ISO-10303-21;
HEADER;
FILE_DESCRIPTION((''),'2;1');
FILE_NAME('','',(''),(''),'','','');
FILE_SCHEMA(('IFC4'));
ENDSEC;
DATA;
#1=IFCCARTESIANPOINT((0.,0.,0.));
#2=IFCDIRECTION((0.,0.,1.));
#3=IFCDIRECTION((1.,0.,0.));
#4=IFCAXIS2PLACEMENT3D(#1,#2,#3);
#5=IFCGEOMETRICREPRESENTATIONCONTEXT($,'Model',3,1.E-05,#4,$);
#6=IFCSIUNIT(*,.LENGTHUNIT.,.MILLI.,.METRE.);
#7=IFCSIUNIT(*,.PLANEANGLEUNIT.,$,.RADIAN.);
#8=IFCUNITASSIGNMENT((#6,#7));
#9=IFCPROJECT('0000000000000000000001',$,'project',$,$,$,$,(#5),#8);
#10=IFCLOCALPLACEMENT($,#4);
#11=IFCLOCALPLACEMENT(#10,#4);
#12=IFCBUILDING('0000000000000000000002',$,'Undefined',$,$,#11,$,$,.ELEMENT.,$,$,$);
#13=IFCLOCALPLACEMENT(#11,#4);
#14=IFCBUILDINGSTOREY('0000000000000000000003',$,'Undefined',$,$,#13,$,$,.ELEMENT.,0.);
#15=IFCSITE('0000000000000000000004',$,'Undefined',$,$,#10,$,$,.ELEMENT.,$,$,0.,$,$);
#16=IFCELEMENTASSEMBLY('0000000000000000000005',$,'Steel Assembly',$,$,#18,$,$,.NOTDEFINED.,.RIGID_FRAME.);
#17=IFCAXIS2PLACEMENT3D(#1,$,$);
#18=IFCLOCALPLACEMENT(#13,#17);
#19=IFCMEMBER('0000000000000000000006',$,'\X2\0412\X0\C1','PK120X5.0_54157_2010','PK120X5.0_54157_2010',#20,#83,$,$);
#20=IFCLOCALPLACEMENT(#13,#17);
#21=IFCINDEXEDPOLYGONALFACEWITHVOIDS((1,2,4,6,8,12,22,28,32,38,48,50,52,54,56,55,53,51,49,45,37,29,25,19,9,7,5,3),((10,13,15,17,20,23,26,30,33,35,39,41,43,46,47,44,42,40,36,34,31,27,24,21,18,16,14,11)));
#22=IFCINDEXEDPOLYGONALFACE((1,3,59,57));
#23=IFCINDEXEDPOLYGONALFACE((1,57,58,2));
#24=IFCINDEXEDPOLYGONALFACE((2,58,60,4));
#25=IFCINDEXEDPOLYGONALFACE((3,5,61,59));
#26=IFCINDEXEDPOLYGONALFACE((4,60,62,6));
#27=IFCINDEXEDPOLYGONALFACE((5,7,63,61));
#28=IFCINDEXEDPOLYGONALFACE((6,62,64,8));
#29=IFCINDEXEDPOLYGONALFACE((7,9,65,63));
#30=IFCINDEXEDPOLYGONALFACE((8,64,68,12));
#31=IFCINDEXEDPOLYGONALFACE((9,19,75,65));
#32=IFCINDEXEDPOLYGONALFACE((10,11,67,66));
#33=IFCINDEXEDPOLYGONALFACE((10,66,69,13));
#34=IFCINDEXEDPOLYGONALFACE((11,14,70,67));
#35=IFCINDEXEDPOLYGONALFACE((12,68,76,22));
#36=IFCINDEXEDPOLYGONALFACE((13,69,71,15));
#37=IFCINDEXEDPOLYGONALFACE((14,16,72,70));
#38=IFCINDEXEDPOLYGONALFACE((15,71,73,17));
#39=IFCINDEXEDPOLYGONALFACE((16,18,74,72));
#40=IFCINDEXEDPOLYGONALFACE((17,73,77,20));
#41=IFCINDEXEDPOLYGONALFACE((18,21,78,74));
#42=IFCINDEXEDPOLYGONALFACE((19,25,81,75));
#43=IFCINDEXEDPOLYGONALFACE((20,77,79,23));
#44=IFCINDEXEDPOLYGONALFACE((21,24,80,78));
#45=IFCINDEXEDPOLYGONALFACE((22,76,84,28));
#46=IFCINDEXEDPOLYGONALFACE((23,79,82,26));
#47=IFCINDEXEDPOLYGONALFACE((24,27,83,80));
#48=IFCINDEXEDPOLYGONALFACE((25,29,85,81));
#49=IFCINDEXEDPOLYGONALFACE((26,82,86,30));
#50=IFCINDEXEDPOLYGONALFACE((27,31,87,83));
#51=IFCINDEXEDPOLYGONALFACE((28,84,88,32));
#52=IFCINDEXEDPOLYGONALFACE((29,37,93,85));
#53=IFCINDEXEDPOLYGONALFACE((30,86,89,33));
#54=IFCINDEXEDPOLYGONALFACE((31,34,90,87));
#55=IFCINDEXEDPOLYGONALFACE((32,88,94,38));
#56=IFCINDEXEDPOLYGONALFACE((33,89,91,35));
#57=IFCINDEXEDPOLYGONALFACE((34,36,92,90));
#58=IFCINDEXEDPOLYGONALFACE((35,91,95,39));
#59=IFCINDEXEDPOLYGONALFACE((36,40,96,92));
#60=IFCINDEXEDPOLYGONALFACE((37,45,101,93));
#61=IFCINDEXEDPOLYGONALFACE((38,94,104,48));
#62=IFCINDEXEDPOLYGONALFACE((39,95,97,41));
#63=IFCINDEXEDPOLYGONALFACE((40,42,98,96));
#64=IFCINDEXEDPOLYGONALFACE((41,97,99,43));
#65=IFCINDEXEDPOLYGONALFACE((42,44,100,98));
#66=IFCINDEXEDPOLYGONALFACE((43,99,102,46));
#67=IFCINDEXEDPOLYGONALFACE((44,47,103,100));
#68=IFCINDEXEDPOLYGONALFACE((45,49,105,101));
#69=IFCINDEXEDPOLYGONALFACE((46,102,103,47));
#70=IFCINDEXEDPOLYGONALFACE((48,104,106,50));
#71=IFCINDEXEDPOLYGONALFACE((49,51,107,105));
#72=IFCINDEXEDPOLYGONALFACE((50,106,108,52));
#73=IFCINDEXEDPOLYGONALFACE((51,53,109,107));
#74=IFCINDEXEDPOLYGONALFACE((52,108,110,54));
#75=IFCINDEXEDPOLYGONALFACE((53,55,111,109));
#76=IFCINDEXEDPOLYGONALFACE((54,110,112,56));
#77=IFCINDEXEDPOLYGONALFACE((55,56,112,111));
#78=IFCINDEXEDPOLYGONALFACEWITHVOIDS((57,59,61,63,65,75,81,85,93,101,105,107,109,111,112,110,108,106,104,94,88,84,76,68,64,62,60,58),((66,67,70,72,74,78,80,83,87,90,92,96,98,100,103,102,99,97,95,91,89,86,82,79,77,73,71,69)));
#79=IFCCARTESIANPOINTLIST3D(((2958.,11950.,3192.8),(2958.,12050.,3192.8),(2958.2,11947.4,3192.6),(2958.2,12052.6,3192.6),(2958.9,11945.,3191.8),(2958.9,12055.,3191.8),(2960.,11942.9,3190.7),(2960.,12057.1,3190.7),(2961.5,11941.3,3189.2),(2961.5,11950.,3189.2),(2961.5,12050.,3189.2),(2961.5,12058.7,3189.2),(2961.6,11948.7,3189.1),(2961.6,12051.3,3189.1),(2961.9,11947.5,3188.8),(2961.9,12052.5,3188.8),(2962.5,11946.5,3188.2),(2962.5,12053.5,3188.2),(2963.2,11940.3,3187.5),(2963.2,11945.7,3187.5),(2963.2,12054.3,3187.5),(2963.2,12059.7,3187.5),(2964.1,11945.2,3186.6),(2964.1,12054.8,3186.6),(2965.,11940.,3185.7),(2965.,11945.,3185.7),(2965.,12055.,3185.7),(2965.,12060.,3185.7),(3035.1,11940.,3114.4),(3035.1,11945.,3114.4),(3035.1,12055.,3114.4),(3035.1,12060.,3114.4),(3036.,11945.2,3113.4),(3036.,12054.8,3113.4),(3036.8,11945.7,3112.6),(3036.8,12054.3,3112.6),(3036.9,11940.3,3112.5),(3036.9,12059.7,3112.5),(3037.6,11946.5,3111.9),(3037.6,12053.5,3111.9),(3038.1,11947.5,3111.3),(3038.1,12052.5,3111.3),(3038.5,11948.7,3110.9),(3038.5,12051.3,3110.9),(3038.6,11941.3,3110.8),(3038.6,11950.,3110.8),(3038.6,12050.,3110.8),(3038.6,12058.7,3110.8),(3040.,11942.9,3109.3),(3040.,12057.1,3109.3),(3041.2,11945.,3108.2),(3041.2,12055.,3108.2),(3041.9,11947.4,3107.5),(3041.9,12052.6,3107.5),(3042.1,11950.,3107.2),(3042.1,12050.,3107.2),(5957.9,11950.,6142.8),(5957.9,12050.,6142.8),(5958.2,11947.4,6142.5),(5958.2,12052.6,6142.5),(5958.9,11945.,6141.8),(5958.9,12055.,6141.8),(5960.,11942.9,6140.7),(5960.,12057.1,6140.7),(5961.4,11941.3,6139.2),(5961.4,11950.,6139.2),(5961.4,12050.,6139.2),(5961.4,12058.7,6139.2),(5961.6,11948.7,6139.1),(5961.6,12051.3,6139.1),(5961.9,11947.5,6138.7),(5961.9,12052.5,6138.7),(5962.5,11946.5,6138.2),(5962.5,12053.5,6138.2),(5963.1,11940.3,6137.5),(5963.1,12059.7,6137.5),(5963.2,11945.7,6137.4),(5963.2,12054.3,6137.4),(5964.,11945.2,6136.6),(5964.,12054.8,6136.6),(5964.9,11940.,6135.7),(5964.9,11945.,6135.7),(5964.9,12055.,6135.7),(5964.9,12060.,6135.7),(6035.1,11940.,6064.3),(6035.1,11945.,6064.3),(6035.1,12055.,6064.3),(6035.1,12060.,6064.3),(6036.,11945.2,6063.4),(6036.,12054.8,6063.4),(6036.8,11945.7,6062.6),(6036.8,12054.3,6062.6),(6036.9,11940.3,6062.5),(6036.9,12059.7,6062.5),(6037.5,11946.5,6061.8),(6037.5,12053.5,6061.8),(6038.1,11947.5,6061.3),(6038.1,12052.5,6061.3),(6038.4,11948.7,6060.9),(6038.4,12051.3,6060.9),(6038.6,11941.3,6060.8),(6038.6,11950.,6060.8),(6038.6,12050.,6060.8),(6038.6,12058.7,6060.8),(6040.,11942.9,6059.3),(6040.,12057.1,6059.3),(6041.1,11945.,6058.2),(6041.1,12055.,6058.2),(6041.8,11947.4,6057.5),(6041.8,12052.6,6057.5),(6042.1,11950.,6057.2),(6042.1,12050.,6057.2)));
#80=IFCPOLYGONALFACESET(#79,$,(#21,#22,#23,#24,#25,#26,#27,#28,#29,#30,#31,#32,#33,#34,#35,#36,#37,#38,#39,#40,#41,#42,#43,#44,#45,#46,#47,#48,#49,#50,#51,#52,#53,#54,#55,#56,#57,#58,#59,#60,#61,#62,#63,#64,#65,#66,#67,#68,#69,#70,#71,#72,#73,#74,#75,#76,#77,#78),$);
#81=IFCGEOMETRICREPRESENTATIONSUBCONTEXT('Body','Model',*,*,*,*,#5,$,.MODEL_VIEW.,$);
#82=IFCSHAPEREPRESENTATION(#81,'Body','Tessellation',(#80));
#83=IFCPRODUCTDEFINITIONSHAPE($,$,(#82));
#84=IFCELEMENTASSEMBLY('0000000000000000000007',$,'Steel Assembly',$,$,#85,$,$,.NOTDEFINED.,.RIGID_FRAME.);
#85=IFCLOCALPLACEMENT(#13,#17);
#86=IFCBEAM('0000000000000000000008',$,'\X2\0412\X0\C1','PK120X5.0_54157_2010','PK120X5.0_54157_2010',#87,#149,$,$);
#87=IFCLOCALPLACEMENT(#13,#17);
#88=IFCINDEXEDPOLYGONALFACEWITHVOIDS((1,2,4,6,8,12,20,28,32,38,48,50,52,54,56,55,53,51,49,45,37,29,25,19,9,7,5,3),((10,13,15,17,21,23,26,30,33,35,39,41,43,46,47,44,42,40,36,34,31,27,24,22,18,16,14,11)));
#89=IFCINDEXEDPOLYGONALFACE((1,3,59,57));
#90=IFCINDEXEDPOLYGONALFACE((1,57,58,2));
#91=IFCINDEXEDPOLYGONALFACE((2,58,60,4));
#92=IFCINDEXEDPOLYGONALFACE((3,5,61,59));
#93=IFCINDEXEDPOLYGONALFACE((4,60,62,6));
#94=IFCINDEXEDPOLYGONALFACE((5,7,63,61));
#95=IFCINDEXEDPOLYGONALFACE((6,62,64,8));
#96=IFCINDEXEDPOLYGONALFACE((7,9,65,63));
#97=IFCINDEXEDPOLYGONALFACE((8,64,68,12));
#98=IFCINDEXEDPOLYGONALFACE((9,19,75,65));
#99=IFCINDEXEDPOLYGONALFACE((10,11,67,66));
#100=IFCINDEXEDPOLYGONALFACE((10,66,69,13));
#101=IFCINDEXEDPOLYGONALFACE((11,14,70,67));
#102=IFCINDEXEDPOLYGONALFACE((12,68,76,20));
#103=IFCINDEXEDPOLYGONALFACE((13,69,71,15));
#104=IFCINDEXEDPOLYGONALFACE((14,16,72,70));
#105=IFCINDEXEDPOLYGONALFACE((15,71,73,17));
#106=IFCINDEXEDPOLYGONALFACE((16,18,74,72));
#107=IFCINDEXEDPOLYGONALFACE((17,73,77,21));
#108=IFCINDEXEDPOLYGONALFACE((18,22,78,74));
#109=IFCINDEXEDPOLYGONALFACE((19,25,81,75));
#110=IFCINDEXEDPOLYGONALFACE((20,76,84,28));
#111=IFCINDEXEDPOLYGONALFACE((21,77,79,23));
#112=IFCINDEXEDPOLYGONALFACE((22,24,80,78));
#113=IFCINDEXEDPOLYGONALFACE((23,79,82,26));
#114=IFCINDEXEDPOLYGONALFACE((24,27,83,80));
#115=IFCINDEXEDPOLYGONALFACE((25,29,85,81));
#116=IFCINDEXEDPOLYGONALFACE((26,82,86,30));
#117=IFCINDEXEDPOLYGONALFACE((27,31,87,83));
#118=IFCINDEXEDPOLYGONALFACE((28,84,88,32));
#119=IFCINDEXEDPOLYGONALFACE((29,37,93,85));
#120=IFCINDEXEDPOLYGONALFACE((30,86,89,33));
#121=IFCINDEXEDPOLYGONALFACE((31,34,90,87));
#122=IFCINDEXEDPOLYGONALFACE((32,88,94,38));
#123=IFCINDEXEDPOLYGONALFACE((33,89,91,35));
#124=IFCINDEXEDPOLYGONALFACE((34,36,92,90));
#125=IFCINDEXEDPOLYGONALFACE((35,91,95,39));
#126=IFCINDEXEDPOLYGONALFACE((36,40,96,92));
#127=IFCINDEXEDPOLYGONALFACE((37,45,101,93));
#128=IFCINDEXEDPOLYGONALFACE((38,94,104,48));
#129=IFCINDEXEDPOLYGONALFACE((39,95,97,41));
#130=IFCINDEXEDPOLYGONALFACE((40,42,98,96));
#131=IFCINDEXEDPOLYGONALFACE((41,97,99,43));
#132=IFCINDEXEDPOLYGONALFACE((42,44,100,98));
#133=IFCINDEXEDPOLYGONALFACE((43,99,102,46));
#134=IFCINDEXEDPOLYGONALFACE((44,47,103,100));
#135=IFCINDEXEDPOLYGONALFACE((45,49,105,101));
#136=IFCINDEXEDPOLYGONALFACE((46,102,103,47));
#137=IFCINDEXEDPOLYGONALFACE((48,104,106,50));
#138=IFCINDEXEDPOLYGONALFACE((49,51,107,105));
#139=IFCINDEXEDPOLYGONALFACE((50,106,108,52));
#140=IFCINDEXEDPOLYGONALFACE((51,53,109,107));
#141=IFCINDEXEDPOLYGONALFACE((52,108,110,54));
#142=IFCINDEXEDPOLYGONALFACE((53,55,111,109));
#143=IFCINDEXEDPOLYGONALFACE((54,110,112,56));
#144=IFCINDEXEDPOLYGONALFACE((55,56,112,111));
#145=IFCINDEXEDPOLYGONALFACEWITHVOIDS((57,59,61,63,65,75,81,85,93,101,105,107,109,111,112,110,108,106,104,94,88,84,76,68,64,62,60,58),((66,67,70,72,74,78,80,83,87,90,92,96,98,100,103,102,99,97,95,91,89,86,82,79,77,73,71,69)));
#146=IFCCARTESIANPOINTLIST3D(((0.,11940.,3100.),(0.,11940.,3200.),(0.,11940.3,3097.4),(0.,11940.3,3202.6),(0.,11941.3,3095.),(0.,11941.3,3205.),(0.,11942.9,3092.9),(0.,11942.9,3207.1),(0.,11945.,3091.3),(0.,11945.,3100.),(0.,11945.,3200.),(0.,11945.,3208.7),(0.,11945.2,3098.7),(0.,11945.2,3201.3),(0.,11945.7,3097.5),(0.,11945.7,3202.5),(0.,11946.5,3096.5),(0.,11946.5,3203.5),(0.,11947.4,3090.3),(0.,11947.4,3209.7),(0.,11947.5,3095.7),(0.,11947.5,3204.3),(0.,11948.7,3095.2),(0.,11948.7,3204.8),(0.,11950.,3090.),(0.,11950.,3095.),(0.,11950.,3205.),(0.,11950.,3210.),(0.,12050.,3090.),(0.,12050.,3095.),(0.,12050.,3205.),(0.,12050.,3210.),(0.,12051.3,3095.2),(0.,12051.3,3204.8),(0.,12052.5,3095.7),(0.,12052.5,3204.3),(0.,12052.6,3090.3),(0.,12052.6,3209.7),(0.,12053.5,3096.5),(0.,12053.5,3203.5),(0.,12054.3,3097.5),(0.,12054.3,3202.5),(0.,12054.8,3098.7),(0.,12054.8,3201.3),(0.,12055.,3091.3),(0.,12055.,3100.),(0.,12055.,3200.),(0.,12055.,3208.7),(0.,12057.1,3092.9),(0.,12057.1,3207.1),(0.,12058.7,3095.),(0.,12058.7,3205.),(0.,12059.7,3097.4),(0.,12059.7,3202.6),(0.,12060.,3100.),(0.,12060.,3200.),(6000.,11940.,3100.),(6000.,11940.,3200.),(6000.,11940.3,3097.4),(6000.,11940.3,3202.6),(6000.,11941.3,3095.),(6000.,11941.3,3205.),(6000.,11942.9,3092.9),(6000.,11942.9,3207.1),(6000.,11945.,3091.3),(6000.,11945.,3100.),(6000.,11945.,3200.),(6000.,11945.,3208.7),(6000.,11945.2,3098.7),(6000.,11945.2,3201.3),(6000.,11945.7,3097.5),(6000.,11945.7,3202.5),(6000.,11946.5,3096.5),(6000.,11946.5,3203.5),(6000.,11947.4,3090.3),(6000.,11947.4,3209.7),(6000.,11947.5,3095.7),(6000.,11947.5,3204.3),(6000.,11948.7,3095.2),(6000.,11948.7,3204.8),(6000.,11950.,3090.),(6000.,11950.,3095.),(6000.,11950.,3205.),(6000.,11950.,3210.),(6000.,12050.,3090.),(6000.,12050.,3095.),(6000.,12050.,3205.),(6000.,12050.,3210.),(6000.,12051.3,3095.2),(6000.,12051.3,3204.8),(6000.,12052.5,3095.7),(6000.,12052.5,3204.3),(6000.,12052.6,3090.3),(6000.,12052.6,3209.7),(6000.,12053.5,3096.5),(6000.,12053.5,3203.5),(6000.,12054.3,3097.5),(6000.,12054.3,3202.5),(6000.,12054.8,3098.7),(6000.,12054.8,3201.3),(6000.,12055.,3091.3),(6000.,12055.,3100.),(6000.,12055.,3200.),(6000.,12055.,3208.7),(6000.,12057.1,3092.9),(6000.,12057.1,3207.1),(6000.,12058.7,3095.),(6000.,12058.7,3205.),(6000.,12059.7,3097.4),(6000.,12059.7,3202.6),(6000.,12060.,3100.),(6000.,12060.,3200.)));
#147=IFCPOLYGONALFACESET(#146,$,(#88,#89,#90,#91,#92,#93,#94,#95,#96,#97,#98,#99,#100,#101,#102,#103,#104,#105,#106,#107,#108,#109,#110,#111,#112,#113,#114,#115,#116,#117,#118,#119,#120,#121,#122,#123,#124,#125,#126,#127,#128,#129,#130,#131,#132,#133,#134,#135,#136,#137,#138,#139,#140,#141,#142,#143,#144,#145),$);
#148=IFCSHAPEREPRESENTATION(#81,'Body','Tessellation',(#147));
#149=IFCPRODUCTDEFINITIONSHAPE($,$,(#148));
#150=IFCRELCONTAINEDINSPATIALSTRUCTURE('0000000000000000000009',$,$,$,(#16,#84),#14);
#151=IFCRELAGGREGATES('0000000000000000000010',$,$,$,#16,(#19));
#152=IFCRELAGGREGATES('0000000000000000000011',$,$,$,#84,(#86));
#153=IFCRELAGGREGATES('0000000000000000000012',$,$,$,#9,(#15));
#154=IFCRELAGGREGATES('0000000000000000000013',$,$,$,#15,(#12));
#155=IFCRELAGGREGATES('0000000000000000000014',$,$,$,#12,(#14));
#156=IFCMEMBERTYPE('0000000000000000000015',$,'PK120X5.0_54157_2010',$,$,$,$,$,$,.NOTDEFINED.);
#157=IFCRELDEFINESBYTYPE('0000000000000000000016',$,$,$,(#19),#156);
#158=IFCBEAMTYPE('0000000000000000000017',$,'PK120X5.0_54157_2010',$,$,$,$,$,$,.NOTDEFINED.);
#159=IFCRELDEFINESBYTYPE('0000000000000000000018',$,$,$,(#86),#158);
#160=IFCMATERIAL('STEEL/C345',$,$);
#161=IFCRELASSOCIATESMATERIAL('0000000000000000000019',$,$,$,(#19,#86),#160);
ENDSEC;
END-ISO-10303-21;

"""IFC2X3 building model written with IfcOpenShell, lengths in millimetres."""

from ifc_helpers import new_model, si_unit, frame, origin_with_axes, origin_2d_with_axis, place, context, subcontext, project, spatial, hollow_rectangle, extrude, material, type_object, element, aggregate, save


model = new_model("IFC2X3")

# Units and contexts
model_context = context("Model", 3, precision=1e-05, world=origin_with_axes())
body_context = subcontext(model_context, "Body", "Model", "MODEL_VIEW")
ifc_project = project(units=[si_unit("LENGTHUNIT", "METRE", prefix="MILLI"), si_unit("PLANEANGLEUNIT", "RADIAN")], contexts=[model_context])

# Site, building, storey
site_placement = place(None, origin_with_axes())
site = spatial("IfcSite", under=ifc_project, at=site_placement, Name="Undefined", CompositionType="ELEMENT", RefElevation=0.0)
building_placement = place(site_placement, origin_with_axes())
building = spatial("IfcBuilding", under=site, at=building_placement, Name="Undefined", CompositionType="ELEMENT")
storey_placement = place(building_placement, origin_with_axes())
storey = spatial("IfcBuildingStorey", under=building, at=storey_placement, Name="Undefined", CompositionType="ELEMENT", Elevation=0.0)

# Shared definitions
ifc_material_1 = material(Name="STEEL/C345")

# Element assembly, member
member_type = type_object("IfcMemberType", Name="PK120X5.0_54157_2010", PredefinedType="NOTDEFINED")
assembly_1_placement = place(storey_placement, origin_with_axes())
assembly_1 = element("IfcElementAssembly", 1, at=assembly_1_placement, inside=storey, Name="Steel Assembly", AssemblyPlace="NOTDEFINED", PredefinedType="RIGID_FRAME")
member_1_placement = place(assembly_1_placement, frame((3000.0, 12000.0, 3150.0), z_axis=(-0.70114, 0.0, 0.713024), x_axis=(0.713024, 0.0, 0.70114)))
member_1 = element("IfcMember", 2, at=member_1_placement, type_object=member_type, material=ifc_material_1, Name="ВC1", Description="PK120X5.0_54157_2010", ObjectType="PK120X5.0_54157_2010", context=body_context, shape_type="SweptSolid", body=[
    extrude(hollow_rectangle(XDim=120.0, YDim=120.0, WallThickness=5.0, InnerFilletRadius=5.0, OuterFilletRadius=10.0, at=origin_2d_with_axis()), frame((4207.4, 0.0, 0.0), z_axis=(-1.0, 0.0, 0.0), x_axis=(0.0, -1.0, 0.0)), (0.0, 0.0, 1.0), 4207.4),
])
aggregate(assembly_1, [member_1])

# Element assembly, beam
assembly_2_placement = place(storey_placement, origin_with_axes())
assembly_2 = element("IfcElementAssembly", 3, at=assembly_2_placement, inside=storey, Name="Steel Assembly", AssemblyPlace="NOTDEFINED", PredefinedType="RIGID_FRAME")
beam_type_1 = type_object("IfcBeamType", Name="PK120X5.0_54157_2010", PredefinedType="NOTDEFINED")
beam_1_placement = place(assembly_2_placement, frame((6000.0, 12000.0, 3150.0), z_axis=(0.0, 0.0, 1.0), x_axis=(-1.0, 0.0, 0.0)))
beam_1 = element("IfcBeam", 4, at=beam_1_placement, type_object=beam_type_1, material=ifc_material_1, Name="ВC1", Description="PK120X5.0_54157_2010", ObjectType="PK120X5.0_54157_2010", context=body_context, shape_type="SweptSolid", body=[
    extrude(hollow_rectangle(XDim=120.0, YDim=120.0, WallThickness=5.0, InnerFilletRadius=5.0, OuterFilletRadius=10.0, at=origin_2d_with_axis()), frame((6000.0, 0.0, 0.0), z_axis=(-1.0, 0.0, 0.0), x_axis=(0.0, -1.0, 0.0)), (0.0, 0.0, 1.0), 6000.0),
])
aggregate(assembly_2, [beam_1])

save(model, "model.ifc")
